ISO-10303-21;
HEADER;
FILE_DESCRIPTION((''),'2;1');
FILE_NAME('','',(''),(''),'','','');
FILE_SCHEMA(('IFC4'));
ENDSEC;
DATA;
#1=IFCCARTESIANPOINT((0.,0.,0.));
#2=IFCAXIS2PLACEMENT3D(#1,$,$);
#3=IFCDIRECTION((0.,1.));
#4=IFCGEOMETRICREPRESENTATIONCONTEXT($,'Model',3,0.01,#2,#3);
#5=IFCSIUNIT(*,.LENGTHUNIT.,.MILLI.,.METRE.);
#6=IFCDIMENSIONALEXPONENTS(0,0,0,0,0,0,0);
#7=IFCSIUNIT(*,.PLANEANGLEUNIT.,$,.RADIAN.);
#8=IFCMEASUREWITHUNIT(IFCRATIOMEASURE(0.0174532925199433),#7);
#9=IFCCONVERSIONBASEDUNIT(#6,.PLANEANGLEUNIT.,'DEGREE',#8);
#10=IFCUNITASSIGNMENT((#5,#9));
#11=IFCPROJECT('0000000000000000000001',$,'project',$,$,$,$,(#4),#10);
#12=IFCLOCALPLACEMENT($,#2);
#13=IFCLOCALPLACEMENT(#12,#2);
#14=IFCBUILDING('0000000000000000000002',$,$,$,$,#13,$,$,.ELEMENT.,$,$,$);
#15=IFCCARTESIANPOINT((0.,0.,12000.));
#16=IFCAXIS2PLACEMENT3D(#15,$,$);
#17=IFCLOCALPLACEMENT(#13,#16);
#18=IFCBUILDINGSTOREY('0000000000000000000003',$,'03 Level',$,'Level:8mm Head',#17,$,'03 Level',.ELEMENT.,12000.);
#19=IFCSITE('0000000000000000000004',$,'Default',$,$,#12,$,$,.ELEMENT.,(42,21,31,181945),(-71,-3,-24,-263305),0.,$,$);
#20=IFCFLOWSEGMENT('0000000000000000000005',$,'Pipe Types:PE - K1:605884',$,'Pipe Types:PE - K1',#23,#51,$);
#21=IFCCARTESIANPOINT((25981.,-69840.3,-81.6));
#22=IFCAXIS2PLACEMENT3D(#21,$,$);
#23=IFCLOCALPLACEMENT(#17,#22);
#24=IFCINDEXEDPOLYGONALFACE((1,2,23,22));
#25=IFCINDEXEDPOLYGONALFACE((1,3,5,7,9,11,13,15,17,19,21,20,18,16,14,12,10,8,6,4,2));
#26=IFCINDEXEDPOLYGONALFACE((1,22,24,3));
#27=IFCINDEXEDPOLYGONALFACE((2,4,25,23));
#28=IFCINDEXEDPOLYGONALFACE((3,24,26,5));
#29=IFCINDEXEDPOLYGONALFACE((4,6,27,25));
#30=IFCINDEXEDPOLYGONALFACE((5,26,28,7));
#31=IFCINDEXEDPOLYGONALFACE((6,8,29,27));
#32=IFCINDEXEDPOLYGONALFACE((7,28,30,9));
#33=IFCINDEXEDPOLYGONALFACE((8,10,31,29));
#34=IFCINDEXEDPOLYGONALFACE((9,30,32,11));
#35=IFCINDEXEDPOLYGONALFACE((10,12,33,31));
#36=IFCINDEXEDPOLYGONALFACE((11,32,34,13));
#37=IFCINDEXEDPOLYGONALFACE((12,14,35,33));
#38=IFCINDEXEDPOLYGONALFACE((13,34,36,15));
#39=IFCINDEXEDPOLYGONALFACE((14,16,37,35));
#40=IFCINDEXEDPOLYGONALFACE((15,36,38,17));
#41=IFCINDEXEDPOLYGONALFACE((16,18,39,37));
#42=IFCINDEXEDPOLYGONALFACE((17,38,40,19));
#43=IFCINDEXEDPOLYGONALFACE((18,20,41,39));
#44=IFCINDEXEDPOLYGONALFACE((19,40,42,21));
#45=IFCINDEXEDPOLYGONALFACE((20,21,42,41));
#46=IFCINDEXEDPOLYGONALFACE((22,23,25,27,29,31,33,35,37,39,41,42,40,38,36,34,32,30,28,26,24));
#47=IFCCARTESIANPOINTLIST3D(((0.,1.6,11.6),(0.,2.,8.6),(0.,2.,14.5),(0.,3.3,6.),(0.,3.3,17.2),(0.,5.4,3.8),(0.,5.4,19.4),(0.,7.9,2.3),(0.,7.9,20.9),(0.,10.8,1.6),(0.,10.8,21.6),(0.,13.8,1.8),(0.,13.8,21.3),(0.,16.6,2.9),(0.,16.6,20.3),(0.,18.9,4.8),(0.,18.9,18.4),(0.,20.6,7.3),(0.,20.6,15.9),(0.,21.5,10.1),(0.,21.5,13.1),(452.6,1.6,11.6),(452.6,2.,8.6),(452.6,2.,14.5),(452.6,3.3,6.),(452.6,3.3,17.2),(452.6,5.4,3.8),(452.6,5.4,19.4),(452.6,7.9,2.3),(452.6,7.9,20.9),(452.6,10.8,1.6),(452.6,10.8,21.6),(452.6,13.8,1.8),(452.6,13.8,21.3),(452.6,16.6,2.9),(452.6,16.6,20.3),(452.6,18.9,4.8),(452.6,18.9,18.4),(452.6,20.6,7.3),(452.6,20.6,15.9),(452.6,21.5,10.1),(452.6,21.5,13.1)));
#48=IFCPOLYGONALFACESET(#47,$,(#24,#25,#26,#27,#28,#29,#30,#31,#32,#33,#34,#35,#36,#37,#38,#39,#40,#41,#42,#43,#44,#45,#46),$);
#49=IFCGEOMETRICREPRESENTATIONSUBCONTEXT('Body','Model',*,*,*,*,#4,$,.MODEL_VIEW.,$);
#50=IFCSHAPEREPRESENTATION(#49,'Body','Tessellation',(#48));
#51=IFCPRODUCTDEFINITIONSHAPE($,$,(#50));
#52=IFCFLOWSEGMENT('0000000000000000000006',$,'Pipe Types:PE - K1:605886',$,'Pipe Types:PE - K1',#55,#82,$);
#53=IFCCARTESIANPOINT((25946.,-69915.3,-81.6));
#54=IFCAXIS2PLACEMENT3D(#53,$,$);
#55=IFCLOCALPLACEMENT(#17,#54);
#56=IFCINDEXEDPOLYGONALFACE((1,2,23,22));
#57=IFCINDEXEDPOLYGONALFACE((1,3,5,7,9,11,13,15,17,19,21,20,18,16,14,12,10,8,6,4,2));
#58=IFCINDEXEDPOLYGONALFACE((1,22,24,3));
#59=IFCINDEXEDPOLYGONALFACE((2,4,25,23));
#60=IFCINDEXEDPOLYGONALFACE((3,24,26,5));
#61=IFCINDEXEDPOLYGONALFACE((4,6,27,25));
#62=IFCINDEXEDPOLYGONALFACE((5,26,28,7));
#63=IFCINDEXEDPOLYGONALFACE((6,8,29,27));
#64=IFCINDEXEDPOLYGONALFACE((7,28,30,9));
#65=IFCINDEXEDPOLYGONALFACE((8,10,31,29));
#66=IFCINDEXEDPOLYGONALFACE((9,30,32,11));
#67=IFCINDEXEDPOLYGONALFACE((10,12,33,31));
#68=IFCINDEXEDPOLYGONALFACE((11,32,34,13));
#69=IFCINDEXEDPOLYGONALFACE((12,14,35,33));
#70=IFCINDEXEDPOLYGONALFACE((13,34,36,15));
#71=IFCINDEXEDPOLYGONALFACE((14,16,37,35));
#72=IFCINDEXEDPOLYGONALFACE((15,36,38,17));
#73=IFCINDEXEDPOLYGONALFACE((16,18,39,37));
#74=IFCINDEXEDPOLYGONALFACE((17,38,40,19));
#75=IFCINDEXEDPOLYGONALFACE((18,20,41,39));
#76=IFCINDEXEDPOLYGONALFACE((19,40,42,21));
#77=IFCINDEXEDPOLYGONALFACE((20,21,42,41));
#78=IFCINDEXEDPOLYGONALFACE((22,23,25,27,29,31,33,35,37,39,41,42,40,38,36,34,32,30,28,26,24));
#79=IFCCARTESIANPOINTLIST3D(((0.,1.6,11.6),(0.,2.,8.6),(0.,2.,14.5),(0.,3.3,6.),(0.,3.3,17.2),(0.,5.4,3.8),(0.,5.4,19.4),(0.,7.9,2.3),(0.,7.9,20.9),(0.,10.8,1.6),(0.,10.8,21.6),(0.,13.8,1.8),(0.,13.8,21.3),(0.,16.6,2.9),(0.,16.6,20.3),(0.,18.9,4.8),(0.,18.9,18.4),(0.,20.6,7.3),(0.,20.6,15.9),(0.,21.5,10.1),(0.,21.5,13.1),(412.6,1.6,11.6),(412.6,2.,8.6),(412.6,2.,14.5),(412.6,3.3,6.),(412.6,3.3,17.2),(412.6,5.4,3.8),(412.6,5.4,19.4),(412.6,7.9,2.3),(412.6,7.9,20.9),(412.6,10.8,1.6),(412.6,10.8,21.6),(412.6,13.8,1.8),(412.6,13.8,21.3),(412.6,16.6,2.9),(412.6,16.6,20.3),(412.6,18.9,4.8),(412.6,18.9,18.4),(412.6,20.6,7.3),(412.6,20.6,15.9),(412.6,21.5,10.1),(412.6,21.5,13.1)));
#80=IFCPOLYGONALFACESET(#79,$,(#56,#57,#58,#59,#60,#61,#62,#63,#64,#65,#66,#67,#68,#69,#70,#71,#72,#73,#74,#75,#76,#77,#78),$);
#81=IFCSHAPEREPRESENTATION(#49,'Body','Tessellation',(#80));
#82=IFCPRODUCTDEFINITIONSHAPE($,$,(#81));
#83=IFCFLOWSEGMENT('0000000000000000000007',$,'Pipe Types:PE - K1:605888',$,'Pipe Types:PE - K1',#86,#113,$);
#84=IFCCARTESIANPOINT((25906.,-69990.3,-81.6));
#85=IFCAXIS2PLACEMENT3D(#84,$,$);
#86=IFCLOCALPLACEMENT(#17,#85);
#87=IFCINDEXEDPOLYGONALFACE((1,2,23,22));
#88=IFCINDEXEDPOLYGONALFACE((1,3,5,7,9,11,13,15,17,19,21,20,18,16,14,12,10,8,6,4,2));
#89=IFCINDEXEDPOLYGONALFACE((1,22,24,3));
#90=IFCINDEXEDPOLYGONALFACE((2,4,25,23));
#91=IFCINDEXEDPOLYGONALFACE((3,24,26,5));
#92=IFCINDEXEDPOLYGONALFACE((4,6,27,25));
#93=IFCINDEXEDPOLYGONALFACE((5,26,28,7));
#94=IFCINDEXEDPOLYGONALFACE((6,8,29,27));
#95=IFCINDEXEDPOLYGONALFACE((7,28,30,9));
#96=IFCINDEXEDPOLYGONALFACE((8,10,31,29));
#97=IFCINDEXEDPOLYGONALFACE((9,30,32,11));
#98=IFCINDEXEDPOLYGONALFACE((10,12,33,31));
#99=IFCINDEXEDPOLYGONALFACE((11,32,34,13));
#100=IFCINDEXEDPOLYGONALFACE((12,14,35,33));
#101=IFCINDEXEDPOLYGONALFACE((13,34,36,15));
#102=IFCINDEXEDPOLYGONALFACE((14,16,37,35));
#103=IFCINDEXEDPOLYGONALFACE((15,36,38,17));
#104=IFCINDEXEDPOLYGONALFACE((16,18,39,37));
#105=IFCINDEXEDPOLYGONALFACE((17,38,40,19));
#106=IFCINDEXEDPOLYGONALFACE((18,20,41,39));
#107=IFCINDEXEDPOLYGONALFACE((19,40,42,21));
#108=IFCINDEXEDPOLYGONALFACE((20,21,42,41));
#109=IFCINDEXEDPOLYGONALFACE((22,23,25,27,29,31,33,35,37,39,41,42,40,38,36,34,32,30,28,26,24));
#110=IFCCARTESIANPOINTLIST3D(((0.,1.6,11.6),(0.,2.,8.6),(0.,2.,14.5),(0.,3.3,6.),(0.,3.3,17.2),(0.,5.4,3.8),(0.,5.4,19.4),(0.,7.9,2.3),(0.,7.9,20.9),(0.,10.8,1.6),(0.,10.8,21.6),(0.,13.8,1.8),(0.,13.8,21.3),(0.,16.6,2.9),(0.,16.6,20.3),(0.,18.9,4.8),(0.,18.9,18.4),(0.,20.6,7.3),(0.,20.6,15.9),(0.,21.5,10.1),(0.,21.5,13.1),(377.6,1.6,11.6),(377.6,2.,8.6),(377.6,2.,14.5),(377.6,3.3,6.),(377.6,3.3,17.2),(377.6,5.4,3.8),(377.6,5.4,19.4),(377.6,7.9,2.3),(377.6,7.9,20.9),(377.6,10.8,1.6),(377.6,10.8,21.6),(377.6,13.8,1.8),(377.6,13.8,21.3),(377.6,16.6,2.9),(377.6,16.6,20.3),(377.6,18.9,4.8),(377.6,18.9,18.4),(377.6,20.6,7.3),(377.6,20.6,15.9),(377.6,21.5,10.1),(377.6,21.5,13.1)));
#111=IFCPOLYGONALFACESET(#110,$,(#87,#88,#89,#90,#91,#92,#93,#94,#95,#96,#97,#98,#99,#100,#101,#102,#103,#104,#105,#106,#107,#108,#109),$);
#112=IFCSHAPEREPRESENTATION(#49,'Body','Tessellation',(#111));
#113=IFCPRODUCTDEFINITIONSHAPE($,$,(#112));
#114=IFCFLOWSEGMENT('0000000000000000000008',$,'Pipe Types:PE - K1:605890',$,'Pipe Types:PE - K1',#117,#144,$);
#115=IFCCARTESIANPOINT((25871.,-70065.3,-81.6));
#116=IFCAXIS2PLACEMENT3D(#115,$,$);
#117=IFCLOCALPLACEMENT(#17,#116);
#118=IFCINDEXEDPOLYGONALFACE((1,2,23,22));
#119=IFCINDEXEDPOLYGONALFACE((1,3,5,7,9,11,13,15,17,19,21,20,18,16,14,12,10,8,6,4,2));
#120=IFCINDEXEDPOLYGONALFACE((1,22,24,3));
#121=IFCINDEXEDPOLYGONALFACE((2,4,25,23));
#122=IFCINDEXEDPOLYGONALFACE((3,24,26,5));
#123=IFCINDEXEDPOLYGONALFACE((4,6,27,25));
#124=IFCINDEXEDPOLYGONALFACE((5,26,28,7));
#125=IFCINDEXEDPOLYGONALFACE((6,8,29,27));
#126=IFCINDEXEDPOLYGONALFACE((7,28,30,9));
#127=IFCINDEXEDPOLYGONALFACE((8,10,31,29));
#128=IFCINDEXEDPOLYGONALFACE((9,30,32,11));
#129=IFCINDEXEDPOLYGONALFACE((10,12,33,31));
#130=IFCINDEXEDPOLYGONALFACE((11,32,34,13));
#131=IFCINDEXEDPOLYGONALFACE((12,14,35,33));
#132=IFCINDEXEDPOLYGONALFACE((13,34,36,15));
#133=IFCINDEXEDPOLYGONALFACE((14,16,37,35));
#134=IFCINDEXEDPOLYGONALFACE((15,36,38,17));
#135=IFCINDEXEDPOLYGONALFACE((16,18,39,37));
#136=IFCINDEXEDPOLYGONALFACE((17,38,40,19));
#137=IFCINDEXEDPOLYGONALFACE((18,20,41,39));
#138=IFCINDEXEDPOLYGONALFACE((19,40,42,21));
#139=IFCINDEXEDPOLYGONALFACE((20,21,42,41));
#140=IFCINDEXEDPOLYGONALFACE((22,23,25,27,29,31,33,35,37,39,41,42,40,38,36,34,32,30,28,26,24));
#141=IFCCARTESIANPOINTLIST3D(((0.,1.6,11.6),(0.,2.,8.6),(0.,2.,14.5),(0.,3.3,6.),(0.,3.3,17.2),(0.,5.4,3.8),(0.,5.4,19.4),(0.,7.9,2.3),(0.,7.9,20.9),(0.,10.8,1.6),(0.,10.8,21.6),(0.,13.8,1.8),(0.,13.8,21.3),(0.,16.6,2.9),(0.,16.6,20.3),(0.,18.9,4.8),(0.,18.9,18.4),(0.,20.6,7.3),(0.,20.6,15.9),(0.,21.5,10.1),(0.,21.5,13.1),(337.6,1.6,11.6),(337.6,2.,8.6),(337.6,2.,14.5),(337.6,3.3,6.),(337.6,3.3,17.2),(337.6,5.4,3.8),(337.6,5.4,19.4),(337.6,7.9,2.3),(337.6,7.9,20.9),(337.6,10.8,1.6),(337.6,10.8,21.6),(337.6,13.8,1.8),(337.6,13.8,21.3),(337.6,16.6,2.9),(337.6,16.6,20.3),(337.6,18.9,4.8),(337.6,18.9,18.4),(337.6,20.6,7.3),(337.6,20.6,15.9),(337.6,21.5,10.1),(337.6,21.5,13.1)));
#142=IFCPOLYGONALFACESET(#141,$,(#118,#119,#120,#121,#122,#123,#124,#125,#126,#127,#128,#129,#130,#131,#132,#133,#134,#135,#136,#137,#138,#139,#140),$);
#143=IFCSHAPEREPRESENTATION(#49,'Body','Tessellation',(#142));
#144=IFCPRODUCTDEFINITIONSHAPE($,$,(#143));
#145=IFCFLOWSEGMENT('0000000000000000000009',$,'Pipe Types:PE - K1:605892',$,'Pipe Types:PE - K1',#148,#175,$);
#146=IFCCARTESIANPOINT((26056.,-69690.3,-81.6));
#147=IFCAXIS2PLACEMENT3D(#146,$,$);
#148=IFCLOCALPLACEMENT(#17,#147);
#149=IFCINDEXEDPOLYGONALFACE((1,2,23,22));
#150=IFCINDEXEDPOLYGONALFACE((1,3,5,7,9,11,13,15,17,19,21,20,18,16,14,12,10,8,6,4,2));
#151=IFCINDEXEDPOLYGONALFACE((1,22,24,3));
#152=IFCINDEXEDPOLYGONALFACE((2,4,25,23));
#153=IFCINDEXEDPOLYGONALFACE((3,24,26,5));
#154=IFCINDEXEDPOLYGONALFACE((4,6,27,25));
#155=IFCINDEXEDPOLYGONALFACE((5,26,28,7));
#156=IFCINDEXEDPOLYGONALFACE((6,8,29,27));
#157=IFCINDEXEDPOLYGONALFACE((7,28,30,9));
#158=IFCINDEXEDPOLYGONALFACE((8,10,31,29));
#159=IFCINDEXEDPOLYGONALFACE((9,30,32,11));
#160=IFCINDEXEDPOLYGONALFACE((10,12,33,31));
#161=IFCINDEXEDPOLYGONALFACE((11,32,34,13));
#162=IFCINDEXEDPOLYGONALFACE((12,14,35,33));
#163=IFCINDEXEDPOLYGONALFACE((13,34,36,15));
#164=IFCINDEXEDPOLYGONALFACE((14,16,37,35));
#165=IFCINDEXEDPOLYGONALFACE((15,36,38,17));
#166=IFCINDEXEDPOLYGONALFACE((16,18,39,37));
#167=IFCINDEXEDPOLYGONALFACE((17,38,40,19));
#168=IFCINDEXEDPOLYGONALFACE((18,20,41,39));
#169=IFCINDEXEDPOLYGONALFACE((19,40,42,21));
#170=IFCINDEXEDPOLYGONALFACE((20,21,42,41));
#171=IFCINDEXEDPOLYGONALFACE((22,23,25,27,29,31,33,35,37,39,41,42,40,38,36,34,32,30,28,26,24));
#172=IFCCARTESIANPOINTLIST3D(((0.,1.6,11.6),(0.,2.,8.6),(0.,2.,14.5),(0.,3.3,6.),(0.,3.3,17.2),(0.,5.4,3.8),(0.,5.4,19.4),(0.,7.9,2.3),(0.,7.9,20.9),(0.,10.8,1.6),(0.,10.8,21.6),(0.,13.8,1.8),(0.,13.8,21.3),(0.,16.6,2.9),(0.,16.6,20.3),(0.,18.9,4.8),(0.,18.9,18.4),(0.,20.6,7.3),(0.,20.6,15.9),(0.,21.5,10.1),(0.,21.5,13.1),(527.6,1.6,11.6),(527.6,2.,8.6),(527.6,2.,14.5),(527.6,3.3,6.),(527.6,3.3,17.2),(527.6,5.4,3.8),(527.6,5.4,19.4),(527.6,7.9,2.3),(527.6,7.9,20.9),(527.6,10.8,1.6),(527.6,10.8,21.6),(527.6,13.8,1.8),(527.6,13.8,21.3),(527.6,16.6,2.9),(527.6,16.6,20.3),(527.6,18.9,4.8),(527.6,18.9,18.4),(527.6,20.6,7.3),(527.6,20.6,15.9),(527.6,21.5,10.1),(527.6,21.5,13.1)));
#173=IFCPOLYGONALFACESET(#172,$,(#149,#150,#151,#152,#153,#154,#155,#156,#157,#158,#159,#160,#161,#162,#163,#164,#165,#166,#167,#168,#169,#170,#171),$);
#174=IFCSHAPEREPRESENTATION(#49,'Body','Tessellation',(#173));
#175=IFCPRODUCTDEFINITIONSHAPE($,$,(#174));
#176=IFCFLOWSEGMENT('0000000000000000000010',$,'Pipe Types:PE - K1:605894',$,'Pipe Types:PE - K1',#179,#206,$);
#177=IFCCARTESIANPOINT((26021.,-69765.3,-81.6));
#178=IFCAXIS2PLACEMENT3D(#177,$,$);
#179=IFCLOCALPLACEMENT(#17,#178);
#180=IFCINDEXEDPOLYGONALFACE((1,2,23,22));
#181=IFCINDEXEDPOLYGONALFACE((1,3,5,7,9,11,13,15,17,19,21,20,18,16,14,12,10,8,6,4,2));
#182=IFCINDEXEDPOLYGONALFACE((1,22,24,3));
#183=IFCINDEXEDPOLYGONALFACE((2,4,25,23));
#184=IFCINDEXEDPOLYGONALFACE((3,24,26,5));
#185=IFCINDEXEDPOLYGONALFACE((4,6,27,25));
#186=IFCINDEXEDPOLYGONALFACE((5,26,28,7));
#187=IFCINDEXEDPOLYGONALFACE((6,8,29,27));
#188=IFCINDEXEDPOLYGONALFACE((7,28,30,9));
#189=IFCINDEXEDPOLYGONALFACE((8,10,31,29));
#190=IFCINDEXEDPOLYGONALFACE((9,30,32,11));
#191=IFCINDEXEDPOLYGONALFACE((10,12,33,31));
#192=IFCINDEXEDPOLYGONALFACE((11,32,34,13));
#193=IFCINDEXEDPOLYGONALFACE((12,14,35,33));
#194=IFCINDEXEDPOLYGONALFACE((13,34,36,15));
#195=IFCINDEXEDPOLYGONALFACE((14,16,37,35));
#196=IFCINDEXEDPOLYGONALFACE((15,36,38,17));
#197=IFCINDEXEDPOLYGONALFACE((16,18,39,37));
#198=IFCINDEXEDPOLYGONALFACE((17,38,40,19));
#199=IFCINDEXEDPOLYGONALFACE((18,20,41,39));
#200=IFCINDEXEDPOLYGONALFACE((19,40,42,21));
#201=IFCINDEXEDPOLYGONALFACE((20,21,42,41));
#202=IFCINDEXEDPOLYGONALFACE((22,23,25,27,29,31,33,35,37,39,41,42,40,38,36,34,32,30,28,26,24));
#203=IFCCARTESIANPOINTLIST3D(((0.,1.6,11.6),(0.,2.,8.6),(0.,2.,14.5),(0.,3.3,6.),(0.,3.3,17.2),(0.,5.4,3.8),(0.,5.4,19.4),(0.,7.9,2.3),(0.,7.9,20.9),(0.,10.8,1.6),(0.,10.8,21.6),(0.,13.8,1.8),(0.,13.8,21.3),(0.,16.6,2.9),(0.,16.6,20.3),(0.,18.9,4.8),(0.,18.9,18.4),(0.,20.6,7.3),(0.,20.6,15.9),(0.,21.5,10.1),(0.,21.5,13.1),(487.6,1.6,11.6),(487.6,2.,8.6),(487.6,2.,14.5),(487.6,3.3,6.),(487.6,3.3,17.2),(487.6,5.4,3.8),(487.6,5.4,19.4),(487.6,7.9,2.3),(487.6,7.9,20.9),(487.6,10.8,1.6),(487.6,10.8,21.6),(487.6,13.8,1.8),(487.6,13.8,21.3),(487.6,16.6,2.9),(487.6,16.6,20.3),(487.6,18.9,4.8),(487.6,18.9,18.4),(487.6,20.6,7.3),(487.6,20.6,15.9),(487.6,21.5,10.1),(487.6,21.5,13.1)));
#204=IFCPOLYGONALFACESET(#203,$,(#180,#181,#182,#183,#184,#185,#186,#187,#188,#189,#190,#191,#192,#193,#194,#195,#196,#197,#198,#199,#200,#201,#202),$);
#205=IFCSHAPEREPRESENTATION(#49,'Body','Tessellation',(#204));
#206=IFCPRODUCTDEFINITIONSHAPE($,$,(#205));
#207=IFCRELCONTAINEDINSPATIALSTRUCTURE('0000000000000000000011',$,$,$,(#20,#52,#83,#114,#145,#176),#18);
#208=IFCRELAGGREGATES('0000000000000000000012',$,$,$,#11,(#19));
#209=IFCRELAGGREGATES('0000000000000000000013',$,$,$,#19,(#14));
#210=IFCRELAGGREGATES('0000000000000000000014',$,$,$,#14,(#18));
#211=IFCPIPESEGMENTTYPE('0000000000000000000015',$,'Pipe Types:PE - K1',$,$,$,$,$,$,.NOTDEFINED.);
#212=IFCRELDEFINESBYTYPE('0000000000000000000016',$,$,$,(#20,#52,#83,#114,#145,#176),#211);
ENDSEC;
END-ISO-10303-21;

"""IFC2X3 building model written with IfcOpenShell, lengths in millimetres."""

from ifc_helpers import new_model, entity, si_unit, converted_unit, direction, frame, frame_2d, origin, origin_2d_with_axis, place, context, subcontext, project, spatial, circle, extrude, type_object, element, save


model = new_model("IFC2X3")

# Units and contexts
model_context = context("Model", 3, precision=0.01, world=origin(), true_north=direction((0.0, 1.0)))
body_context = subcontext(model_context, "Body", "Model", "MODEL_VIEW")
ifc_project = project(units=[si_unit("LENGTHUNIT", "METRE", prefix="MILLI"), converted_unit("PLANEANGLEUNIT", "DEGREE", entity("IfcRatioMeasure", 0.0174532925199433), si_unit("PLANEANGLEUNIT", "RADIAN"), dimensions=[0, 0, 0, 0, 0, 0, 0])], contexts=[model_context])

# Site, building, storey
site_placement = place(None, origin())
site = spatial("IfcSite", under=ifc_project, at=site_placement, Name="Default", CompositionType="ELEMENT", RefLatitude=(42, 21, 31, 181945), RefLongitude=(-71, -3, -24, -263305), RefElevation=0.0)
building_placement = place(site_placement, origin())
building = spatial("IfcBuilding", under=site, at=building_placement, CompositionType="ELEMENT")
storey_placement = place(building_placement, frame((0.0, 0.0, 12000.0)))
storey = spatial("IfcBuildingStorey", under=building, at=storey_placement, Name="03 Level", ObjectType="Level:8mm Head", LongName="03 Level", CompositionType="ELEMENT", Elevation=12000.0)

# Flow segments
pipe_segment_type = type_object("IfcPipeSegmentType", Name="Pipe Types:PE - K1", PredefinedType="NOTDEFINED")
flow_segment_1_placement = place(storey_placement, frame((25981.0, -69840.3, -81.6)))
element("IfcFlowSegment", 1, at=flow_segment_1_placement, inside=storey, type_object=pipe_segment_type, Name="Pipe Types:PE - K1:605884", ObjectType="Pipe Types:PE - K1", context=body_context, shape_type="SweptSolid", body=[
    extrude(circle(Radius=10.0, at=frame_2d((0.0, 0.0), x_axis=(1.0, 0.0))), frame((0.0, 11.6, 11.6), z_axis=(1.0, 0.0, 0.0), x_axis=(0.0, -1.0, 0.0)), (0.0, 0.0, 1.0), 452.6),
])
flow_segment_2_placement = place(storey_placement, frame((25946.0, -69915.3, -81.6)))
element("IfcFlowSegment", 2, at=flow_segment_2_placement, inside=storey, type_object=pipe_segment_type, Name="Pipe Types:PE - K1:605886", ObjectType="Pipe Types:PE - K1", context=body_context, shape_type="SweptSolid", body=[
    extrude(circle(Radius=10.0, at=origin_2d_with_axis()), frame((0.0, 11.6, 11.6), z_axis=(1.0, 0.0, 0.0), x_axis=(0.0, -1.0, 0.0)), (0.0, 0.0, 1.0), 412.6),
])
flow_segment_3_placement = place(storey_placement, frame((25906.0, -69990.3, -81.6)))
element("IfcFlowSegment", 3, at=flow_segment_3_placement, inside=storey, type_object=pipe_segment_type, Name="Pipe Types:PE - K1:605888", ObjectType="Pipe Types:PE - K1", context=body_context, shape_type="SweptSolid", body=[
    extrude(circle(Radius=10.0, at=frame_2d((0.0, 0.0), x_axis=(1.0, 0.0))), frame((0.0, 11.6, 11.6), z_axis=(1.0, 0.0, 0.0), x_axis=(0.0, -1.0, 0.0)), (0.0, 0.0, 1.0), 377.6),
])
flow_segment_4_placement = place(storey_placement, frame((25871.0, -70065.3, -81.6)))
element("IfcFlowSegment", 4, at=flow_segment_4_placement, inside=storey, type_object=pipe_segment_type, Name="Pipe Types:PE - K1:605890", ObjectType="Pipe Types:PE - K1", context=body_context, shape_type="SweptSolid", body=[
    extrude(circle(Radius=10.0, at=frame_2d((0.0, 0.0), x_axis=(1.0, 0.0))), frame((0.0, 11.6, 11.6), z_axis=(1.0, 0.0, 0.0), x_axis=(0.0, -1.0, 0.0)), (0.0, 0.0, 1.0), 337.6),
])
flow_segment_5_placement = place(storey_placement, frame((26056.0, -69690.3, -81.6)))
element("IfcFlowSegment", 5, at=flow_segment_5_placement, inside=storey, type_object=pipe_segment_type, Name="Pipe Types:PE - K1:605892", ObjectType="Pipe Types:PE - K1", context=body_context, shape_type="SweptSolid", body=[
    extrude(circle(Radius=10.0, at=origin_2d_with_axis()), frame((0.0, 11.6, 11.6), z_axis=(1.0, 0.0, 0.0), x_axis=(0.0, -1.0, 0.0)), (0.0, 0.0, 1.0), 527.6),
])
flow_segment_6_placement = place(storey_placement, frame((26021.0, -69765.3, -81.6)))
element("IfcFlowSegment", 6, at=flow_segment_6_placement, inside=storey, type_object=pipe_segment_type, Name="Pipe Types:PE - K1:605894", ObjectType="Pipe Types:PE - K1", context=body_context, shape_type="SweptSolid", body=[
    extrude(circle(Radius=10.0, at=frame_2d((0.0, 0.0), x_axis=(1.0, 0.0))), frame((0.0, 11.6, 11.6), z_axis=(1.0, 0.0, 0.0), x_axis=(0.0, -1.0, 0.0)), (0.0, 0.0, 1.0), 487.6),
])

save(model, "model.ifc")
